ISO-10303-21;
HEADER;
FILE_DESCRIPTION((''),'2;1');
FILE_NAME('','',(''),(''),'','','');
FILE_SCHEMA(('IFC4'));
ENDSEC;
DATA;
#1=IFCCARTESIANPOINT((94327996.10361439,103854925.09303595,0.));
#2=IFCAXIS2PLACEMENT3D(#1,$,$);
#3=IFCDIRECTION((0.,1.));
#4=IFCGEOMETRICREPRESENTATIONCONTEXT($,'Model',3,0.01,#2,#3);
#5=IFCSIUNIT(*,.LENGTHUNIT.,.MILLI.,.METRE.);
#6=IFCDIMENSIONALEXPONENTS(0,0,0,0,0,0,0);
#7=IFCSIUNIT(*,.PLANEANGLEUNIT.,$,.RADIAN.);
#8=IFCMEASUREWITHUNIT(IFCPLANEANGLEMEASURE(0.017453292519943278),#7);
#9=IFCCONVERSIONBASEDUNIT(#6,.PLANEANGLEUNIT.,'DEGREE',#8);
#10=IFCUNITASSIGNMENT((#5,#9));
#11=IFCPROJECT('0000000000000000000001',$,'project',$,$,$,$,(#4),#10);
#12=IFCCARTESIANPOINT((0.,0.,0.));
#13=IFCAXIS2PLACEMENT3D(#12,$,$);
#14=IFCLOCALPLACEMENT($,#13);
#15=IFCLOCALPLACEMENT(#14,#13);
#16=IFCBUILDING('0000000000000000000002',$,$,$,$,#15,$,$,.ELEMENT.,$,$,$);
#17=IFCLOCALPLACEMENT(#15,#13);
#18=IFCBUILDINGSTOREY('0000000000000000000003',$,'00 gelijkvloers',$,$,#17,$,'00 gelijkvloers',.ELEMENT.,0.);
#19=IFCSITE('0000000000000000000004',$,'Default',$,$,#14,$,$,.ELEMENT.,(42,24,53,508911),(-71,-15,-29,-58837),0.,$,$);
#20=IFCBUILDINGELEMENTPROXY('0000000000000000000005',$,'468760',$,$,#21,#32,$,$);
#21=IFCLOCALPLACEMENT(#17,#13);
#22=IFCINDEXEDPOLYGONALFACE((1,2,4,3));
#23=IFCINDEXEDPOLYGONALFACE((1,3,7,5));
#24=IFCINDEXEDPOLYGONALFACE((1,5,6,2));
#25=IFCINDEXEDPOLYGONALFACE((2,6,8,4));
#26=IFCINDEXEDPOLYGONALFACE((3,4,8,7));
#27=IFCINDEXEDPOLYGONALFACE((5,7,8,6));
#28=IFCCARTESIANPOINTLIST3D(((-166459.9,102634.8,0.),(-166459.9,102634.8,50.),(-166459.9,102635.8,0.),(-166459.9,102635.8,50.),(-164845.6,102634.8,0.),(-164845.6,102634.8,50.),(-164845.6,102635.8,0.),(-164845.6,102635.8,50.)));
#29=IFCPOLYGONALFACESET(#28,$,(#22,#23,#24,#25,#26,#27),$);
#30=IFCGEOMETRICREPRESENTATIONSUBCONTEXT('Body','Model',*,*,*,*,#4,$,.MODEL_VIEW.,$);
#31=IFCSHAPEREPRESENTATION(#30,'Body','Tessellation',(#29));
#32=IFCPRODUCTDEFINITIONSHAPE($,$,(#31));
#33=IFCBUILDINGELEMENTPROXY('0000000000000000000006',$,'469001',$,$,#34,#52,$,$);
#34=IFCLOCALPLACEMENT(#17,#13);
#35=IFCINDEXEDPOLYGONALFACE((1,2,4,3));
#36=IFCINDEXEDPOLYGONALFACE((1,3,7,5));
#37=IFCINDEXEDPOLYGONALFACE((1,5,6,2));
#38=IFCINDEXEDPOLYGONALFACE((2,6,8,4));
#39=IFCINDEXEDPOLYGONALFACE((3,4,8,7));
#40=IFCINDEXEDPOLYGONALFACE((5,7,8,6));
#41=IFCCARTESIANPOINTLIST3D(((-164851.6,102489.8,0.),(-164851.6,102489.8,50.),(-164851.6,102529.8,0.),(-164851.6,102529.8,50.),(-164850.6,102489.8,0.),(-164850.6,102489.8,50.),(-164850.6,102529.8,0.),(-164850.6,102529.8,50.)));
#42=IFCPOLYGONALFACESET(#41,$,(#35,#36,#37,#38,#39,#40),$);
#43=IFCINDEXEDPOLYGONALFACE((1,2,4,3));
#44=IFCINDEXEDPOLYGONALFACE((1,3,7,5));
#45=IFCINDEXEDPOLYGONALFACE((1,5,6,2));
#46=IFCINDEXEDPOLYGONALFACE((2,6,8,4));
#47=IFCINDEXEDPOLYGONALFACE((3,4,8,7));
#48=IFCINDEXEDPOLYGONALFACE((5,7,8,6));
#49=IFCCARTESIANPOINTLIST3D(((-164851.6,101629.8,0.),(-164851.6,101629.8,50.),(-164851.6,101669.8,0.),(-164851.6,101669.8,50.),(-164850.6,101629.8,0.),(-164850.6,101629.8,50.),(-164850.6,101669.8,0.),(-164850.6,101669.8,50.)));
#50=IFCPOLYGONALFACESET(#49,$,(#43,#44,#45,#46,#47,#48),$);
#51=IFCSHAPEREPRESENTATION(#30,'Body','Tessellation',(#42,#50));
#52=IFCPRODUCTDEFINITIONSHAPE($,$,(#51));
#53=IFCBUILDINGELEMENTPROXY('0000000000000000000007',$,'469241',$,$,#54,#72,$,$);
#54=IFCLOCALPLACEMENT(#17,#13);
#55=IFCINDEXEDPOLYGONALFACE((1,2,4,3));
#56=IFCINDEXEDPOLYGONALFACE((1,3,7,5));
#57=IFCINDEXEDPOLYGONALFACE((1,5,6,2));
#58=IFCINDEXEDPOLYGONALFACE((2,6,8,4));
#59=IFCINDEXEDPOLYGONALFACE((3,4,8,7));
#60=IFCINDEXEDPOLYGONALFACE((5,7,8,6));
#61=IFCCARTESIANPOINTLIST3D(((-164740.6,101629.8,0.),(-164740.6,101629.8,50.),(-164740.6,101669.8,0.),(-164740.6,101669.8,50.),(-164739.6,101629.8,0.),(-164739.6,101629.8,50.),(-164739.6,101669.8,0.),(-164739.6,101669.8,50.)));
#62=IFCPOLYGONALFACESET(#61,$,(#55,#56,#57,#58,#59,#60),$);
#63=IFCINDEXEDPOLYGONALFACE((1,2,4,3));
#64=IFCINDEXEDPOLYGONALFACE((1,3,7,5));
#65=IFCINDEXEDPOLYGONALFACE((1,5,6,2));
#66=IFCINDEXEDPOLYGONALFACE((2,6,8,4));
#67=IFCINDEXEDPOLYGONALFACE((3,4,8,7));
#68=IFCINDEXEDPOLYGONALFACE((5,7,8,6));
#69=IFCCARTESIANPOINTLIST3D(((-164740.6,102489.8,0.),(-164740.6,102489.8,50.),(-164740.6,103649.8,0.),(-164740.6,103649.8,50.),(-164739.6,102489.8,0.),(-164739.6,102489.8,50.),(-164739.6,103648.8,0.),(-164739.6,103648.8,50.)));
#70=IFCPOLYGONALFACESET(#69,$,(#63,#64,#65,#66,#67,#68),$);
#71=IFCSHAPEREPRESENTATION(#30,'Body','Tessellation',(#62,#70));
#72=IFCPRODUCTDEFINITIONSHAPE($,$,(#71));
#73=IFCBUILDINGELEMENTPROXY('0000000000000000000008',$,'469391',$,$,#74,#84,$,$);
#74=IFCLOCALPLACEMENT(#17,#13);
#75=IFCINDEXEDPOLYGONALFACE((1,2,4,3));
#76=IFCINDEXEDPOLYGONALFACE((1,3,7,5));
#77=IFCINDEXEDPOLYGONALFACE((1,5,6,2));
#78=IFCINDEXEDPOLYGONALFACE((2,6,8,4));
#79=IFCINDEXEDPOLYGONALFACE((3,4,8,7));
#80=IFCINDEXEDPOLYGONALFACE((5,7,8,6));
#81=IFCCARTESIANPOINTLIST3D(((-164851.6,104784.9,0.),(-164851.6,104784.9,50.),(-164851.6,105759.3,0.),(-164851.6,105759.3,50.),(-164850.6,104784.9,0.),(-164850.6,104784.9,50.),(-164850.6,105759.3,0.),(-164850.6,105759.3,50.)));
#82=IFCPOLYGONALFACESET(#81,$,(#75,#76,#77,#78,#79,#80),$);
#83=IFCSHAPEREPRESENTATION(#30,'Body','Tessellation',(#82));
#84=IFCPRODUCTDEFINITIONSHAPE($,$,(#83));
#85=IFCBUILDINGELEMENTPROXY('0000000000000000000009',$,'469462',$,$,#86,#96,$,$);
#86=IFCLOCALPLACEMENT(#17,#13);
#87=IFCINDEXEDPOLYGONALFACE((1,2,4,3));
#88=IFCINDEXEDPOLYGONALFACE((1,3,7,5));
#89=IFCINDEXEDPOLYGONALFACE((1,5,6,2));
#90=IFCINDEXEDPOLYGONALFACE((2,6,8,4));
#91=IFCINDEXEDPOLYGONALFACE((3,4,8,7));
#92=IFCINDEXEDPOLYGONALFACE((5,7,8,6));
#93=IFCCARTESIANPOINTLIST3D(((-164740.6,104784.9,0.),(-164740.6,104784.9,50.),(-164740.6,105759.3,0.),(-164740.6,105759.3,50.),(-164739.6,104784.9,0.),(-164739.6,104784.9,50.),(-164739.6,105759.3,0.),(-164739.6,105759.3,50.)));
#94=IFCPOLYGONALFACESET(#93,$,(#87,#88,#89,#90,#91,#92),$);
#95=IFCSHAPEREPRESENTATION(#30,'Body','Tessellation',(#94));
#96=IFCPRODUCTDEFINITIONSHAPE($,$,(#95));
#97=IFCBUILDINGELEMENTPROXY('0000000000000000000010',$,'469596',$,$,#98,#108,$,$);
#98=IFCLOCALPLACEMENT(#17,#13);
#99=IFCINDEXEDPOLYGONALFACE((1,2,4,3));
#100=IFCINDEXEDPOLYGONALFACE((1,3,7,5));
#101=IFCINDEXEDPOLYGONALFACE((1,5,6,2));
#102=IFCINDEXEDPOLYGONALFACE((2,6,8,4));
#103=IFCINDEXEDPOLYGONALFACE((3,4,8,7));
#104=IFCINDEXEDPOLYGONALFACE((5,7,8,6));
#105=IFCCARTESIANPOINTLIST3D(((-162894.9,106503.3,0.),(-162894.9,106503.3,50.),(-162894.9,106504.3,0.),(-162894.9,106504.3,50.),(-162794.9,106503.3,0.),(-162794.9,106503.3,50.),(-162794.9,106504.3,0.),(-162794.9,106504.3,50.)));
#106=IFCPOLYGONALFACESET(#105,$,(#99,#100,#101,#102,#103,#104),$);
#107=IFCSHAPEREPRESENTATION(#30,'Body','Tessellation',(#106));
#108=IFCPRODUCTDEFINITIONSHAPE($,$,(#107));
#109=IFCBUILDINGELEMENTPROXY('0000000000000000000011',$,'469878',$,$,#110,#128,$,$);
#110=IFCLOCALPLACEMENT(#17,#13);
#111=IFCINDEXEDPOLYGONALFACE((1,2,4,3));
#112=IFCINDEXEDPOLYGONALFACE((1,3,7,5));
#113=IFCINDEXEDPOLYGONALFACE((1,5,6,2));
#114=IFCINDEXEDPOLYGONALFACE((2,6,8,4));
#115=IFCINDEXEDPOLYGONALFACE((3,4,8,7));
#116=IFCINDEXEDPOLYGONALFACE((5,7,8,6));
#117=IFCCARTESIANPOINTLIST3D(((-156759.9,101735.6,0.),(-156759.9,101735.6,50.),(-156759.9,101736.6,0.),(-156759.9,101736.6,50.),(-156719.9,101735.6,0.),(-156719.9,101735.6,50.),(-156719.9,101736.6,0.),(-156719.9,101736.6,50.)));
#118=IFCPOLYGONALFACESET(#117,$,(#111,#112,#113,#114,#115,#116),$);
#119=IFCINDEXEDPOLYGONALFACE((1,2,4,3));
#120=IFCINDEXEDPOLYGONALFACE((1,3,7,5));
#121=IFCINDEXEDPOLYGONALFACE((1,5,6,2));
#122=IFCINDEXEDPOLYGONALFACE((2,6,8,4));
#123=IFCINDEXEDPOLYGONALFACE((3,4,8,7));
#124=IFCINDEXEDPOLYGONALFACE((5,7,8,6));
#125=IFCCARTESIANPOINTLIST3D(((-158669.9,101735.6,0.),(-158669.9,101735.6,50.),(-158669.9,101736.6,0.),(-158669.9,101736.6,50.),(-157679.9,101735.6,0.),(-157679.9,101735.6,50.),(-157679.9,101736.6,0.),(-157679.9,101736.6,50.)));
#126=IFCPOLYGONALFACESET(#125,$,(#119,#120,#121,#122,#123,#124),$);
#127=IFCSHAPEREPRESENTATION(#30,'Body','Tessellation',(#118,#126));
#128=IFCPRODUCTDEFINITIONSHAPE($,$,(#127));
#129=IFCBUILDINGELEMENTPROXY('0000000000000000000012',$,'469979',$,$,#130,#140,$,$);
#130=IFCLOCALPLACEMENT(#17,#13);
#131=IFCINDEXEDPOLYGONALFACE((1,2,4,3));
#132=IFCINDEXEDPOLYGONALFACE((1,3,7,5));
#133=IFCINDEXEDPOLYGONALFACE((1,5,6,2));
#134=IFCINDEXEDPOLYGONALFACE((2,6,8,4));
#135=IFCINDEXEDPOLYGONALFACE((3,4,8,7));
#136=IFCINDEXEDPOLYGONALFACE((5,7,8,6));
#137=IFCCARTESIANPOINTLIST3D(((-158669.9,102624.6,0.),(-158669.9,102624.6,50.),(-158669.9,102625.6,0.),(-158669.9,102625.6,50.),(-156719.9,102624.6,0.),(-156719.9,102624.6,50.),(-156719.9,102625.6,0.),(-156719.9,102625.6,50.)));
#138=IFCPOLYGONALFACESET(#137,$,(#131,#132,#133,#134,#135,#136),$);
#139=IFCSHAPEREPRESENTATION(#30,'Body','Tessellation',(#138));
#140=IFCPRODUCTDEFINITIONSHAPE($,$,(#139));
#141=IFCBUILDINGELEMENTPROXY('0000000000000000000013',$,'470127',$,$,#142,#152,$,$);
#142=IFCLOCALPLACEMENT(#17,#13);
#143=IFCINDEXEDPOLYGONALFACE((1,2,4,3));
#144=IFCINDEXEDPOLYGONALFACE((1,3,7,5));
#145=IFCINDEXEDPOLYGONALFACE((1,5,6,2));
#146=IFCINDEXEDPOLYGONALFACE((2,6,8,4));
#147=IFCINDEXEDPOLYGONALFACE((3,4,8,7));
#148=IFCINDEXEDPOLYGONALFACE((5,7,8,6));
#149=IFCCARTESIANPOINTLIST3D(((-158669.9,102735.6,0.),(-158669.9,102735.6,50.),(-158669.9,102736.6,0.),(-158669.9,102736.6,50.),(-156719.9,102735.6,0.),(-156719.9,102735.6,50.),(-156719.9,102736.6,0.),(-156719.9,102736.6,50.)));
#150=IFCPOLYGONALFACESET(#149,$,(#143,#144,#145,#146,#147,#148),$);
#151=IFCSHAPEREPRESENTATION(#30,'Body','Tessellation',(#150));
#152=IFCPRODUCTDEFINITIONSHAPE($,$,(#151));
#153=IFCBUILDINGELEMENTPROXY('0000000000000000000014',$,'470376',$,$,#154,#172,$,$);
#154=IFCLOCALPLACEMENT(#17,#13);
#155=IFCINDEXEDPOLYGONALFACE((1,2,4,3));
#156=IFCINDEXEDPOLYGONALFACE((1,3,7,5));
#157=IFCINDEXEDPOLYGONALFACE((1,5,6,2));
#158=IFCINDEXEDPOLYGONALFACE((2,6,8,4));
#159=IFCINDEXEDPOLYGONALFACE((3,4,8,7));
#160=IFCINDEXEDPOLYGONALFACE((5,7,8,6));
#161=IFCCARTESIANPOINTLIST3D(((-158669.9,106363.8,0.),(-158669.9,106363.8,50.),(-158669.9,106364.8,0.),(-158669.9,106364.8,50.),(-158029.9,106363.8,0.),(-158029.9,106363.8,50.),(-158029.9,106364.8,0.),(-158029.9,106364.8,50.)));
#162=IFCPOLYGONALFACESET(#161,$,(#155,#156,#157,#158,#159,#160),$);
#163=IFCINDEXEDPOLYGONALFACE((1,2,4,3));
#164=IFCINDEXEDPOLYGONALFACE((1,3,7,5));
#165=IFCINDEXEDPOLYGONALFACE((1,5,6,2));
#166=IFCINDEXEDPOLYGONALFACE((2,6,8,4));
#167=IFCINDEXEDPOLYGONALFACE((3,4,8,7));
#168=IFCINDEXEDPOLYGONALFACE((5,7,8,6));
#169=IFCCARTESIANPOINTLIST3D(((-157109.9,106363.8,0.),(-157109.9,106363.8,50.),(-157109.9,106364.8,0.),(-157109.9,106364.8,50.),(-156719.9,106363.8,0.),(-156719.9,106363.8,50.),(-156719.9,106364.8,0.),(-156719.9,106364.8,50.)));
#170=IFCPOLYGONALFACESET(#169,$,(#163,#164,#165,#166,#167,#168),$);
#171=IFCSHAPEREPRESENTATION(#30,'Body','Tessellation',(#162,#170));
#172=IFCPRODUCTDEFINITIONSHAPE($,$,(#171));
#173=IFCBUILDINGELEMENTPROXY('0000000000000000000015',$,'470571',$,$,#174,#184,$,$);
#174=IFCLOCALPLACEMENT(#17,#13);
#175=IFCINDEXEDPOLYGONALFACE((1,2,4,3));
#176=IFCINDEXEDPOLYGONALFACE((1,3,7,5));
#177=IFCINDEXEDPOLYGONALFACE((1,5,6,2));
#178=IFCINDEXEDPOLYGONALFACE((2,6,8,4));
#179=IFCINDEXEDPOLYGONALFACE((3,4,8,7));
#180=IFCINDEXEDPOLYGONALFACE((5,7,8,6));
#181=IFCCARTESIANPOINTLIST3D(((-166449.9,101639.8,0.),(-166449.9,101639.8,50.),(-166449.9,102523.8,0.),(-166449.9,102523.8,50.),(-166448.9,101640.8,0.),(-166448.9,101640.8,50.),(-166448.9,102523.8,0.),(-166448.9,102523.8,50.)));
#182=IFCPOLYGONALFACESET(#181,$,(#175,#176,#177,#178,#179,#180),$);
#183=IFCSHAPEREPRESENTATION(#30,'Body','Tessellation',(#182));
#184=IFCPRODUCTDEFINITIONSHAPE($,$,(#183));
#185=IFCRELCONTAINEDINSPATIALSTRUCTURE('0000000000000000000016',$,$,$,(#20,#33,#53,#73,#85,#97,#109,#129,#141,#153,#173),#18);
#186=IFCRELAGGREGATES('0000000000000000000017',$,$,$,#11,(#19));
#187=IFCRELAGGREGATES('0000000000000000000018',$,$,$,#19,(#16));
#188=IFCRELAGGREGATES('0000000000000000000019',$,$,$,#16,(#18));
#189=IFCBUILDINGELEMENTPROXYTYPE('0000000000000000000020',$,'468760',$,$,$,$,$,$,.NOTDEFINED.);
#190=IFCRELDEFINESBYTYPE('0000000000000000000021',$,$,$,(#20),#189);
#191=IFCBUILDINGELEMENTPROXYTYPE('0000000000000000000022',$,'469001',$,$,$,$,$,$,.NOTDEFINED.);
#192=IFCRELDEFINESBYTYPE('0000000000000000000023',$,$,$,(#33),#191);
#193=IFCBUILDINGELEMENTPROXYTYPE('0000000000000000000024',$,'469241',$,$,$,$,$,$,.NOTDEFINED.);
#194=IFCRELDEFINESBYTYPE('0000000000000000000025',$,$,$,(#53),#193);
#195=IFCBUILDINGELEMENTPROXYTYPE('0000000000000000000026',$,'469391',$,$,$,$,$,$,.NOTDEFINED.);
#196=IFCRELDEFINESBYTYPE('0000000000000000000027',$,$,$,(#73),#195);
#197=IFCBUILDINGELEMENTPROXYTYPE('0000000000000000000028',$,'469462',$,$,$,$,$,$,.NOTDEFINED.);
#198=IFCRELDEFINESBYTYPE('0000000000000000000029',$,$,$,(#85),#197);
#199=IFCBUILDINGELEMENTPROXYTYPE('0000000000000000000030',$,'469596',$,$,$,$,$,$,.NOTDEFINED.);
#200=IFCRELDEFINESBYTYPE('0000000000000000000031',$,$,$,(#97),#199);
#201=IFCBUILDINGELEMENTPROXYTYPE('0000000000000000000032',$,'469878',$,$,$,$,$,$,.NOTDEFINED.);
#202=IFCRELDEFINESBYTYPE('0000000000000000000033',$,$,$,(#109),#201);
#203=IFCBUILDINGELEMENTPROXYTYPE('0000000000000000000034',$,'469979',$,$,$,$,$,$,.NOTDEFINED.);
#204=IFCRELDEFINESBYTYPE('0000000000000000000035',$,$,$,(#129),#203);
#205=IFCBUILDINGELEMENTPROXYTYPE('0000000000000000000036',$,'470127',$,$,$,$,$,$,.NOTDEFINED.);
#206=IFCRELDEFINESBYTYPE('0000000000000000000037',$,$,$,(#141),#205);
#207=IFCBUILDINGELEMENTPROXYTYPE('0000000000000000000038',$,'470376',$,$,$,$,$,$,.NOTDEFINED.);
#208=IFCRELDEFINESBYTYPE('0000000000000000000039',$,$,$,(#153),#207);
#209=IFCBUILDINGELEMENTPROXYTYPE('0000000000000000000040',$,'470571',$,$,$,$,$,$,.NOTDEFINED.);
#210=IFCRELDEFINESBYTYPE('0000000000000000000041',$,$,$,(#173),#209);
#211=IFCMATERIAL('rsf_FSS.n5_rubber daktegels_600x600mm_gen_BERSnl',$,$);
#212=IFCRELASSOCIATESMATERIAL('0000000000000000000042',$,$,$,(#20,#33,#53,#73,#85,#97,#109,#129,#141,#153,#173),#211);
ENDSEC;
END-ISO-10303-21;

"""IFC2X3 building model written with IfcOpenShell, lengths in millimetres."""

from ifc_helpers import new_model, entity, si_unit, converted_unit, direction, frame, frame_2d, origin, place, context, subcontext, project, spatial, polyline, rectangle, outline, extrude, material, type_object, element, save


model = new_model("IFC2X3")

# Units and contexts
model_context = context("Model", 3, precision=0.01, world=frame((94327996.10361439, 103854925.09303595, 0.0)), true_north=direction((0.0, 1.0)))
body_context = subcontext(model_context, "Body", "Model", "MODEL_VIEW")
ifc_project = project(units=[si_unit("LENGTHUNIT", "METRE", prefix="MILLI"), converted_unit("PLANEANGLEUNIT", "DEGREE", entity("IfcPlaneAngleMeasure", 0.017453292519943278), si_unit("PLANEANGLEUNIT", "RADIAN"), dimensions=[0, 0, 0, 0, 0, 0, 0])], contexts=[model_context])

# Site, building, storey
site_placement = place(None, origin())
site = spatial("IfcSite", under=ifc_project, at=site_placement, Name="Default", CompositionType="ELEMENT", RefLatitude=(42, 24, 53, 508911), RefLongitude=(-71, -15, -29, -58837), RefElevation=0.0)
building_placement = place(site_placement, origin())
building = spatial("IfcBuilding", under=site, at=building_placement, CompositionType="ELEMENT")
storey_placement = place(building_placement, origin())
storey = spatial("IfcBuildingStorey", under=building, at=storey_placement, Name="00 gelijkvloers", LongName="00 gelijkvloers", CompositionType="ELEMENT", Elevation=0.0)

# Building element proxies
ifc_material_1 = material(Name="rsf_FSS.n5_rubber daktegels_600x600mm_gen_BERSnl")
building_element_proxy_type_1 = type_object("IfcBuildingElementProxyType", Name="468760", PredefinedType="NOTDEFINED")
proxy_1_placement = place(storey_placement, origin())
element("IfcBuildingElementProxy", 1, at=proxy_1_placement, inside=storey, type_object=building_element_proxy_type_1, material=ifc_material_1, Name="468760", context=body_context, shape_type="SweptSolid", body=[
    extrude(rectangle(XDim=1614.3, YDim=1.0, at=frame_2d((0.0, 0.0), x_axis=(1.0, 0.0))), frame((-165652.7, 102635.3, 0.0)), (0.0, 0.0, 1.0), 50.0),
])
building_element_proxy_type_2 = type_object("IfcBuildingElementProxyType", Name="469001", PredefinedType="NOTDEFINED")
proxy_2_placement = place(storey_placement, origin())
element("IfcBuildingElementProxy", 2, at=proxy_2_placement, inside=storey, type_object=building_element_proxy_type_2, material=ifc_material_1, Name="469001", context=body_context, shape_type="SweptSolid", body=[
    extrude(rectangle(XDim=40.0, YDim=1.0, at=frame_2d((0.0, 0.0), x_axis=(1.0, 0.0))), frame((-164851.1, 102509.8, 0.0), z_axis=(0.0, 0.0, 1.0), x_axis=(0.0, 1.0, 0.0)), (0.0, 0.0, 1.0), 50.0),
    extrude(rectangle(XDim=40.0, YDim=1.0, at=frame_2d((0.0, 0.0), x_axis=(1.0, 0.0))), frame((-164851.1, 101649.8, 0.0), z_axis=(0.0, 0.0, 1.0), x_axis=(0.0, 1.0, 0.0)), (0.0, 0.0, 1.0), 50.0),
])
building_element_proxy_type_3 = type_object("IfcBuildingElementProxyType", Name="469241", PredefinedType="NOTDEFINED")
proxy_3_placement = place(storey_placement, origin())
element("IfcBuildingElementProxy", 3, at=proxy_3_placement, inside=storey, type_object=building_element_proxy_type_3, material=ifc_material_1, Name="469241", context=body_context, shape_type="SweptSolid", body=[
    extrude(rectangle(XDim=40.0, YDim=1.0, at=frame_2d((0.0, 0.0), x_axis=(1.0, 0.0))), frame((-164740.1, 101649.8, 0.0), z_axis=(0.0, 0.0, 1.0), x_axis=(0.0, 1.0, 0.0)), (0.0, 0.0, 1.0), 50.0),
    extrude(outline(polyline([(-579.8, -0.5), (579.3, -0.5), (580.3, 0.5), (-579.8, 0.5), (-579.8, -0.5)])), frame((-164740.1, 103069.5, 0.0), z_axis=(0.0, 0.0, 1.0), x_axis=(0.0, 1.0, 0.0)), (0.0, 0.0, 1.0), 50.0),
])
building_element_proxy_type_4 = type_object("IfcBuildingElementProxyType", Name="469391", PredefinedType="NOTDEFINED")
proxy_4_placement = place(storey_placement, origin())
element("IfcBuildingElementProxy", 4, at=proxy_4_placement, inside=storey, type_object=building_element_proxy_type_4, material=ifc_material_1, Name="469391", context=body_context, shape_type="SweptSolid", body=[
    extrude(rectangle(XDim=974.4, YDim=1.0, at=frame_2d((0.0, 0.0), x_axis=(1.0, 0.0))), frame((-164851.1, 105272.1, 0.0), z_axis=(0.0, 0.0, 1.0), x_axis=(0.0, 1.0, 0.0)), (0.0, 0.0, 1.0), 50.0),
])
building_element_proxy_type_5 = type_object("IfcBuildingElementProxyType", Name="469462", PredefinedType="NOTDEFINED")
proxy_5_placement = place(storey_placement, origin())
element("IfcBuildingElementProxy", 5, at=proxy_5_placement, inside=storey, type_object=building_element_proxy_type_5, material=ifc_material_1, Name="469462", context=body_context, shape_type="SweptSolid", body=[
    extrude(rectangle(XDim=974.4, YDim=1.0, at=frame_2d((0.0, 0.0), x_axis=(1.0, 0.0))), frame((-164740.1, 105272.1, 0.0), z_axis=(0.0, 0.0, 1.0), x_axis=(0.0, -1.0, 0.0)), (0.0, 0.0, 1.0), 50.0),
])
building_element_proxy_type_6 = type_object("IfcBuildingElementProxyType", Name="469596", PredefinedType="NOTDEFINED")
proxy_6_placement = place(storey_placement, origin())
element("IfcBuildingElementProxy", 6, at=proxy_6_placement, inside=storey, type_object=building_element_proxy_type_6, material=ifc_material_1, Name="469596", context=body_context, shape_type="SweptSolid", body=[
    extrude(rectangle(XDim=100.0, YDim=1.0, at=frame_2d((0.0, 0.0), x_axis=(1.0, 0.0))), frame((-162844.9, 106503.8, 0.0), z_axis=(0.0, 0.0, 1.0), x_axis=(-1.0, 0.0, 0.0)), (0.0, 0.0, 1.0), 50.0),
])
building_element_proxy_type_7 = type_object("IfcBuildingElementProxyType", Name="469878", PredefinedType="NOTDEFINED")
proxy_7_placement = place(storey_placement, origin())
element("IfcBuildingElementProxy", 7, at=proxy_7_placement, inside=storey, type_object=building_element_proxy_type_7, material=ifc_material_1, Name="469878", context=body_context, shape_type="SweptSolid", body=[
    extrude(rectangle(XDim=40.0, YDim=1.0, at=frame_2d((0.0, 0.0), x_axis=(1.0, 0.0))), frame((-156739.9, 101736.1, 0.0)), (0.0, 0.0, 1.0), 50.0),
    extrude(rectangle(XDim=990.0, YDim=1.0, at=frame_2d((0.0, 0.0), x_axis=(1.0, 0.0))), frame((-158174.9, 101736.1, 0.0)), (0.0, 0.0, 1.0), 50.0),
])
building_element_proxy_type_8 = type_object("IfcBuildingElementProxyType", Name="469979", PredefinedType="NOTDEFINED")
proxy_8_placement = place(storey_placement, origin())
element("IfcBuildingElementProxy", 8, at=proxy_8_placement, inside=storey, type_object=building_element_proxy_type_8, material=ifc_material_1, Name="469979", context=body_context, shape_type="SweptSolid", body=[
    extrude(rectangle(XDim=1950.0, YDim=1.0, at=frame_2d((0.0, 0.0), x_axis=(1.0, 0.0))), frame((-157694.9, 102625.1, 0.0), z_axis=(0.0, 0.0, 1.0), x_axis=(-1.0, 0.0, 0.0)), (0.0, 0.0, 1.0), 50.0),
])
building_element_proxy_type_9 = type_object("IfcBuildingElementProxyType", Name="470127", PredefinedType="NOTDEFINED")
proxy_9_placement = place(storey_placement, origin())
element("IfcBuildingElementProxy", 9, at=proxy_9_placement, inside=storey, type_object=building_element_proxy_type_9, material=ifc_material_1, Name="470127", context=body_context, shape_type="SweptSolid", body=[
    extrude(rectangle(XDim=1950.0, YDim=1.0, at=frame_2d((0.0, 0.0), x_axis=(1.0, 0.0))), frame((-157694.9, 102736.1, 0.0)), (0.0, 0.0, 1.0), 50.0),
])
building_element_proxy_type_10 = type_object("IfcBuildingElementProxyType", Name="470376", PredefinedType="NOTDEFINED")
proxy_10_placement = place(storey_placement, origin())
element("IfcBuildingElementProxy", 10, at=proxy_10_placement, inside=storey, type_object=building_element_proxy_type_10, material=ifc_material_1, Name="470376", context=body_context, shape_type="SweptSolid", body=[
    extrude(rectangle(XDim=640.0, YDim=1.0, at=frame_2d((0.0, 0.0), x_axis=(1.0, 0.0))), frame((-158349.9, 106364.3, 0.0), z_axis=(0.0, 0.0, 1.0), x_axis=(-1.0, 0.0, 0.0)), (0.0, 0.0, 1.0), 50.0),
    extrude(rectangle(XDim=390.0, YDim=1.0, at=frame_2d((0.0, 0.0), x_axis=(1.0, 0.0))), frame((-156914.9, 106364.3, 0.0), z_axis=(0.0, 0.0, 1.0), x_axis=(-1.0, 0.0, 0.0)), (0.0, 0.0, 1.0), 50.0),
])
building_element_proxy_type_11 = type_object("IfcBuildingElementProxyType", Name="470571", PredefinedType="NOTDEFINED")
proxy_11_placement = place(storey_placement, origin())
element("IfcBuildingElementProxy", 11, at=proxy_11_placement, inside=storey, type_object=building_element_proxy_type_11, material=ifc_material_1, Name="470571", context=body_context, shape_type="SweptSolid", body=[
    extrude(outline(polyline([(-441.7, -0.5), (442.3, -0.5), (441.2, 0.5), (-441.7, 0.5), (-441.7, -0.5)])), frame((-166449.4, 102082.0, 0.0), z_axis=(0.0, 0.0, 1.0), x_axis=(0.0, -1.0, 0.0)), (0.0, 0.0, 1.0), 50.0),
])

save(model, "model.ifc")
